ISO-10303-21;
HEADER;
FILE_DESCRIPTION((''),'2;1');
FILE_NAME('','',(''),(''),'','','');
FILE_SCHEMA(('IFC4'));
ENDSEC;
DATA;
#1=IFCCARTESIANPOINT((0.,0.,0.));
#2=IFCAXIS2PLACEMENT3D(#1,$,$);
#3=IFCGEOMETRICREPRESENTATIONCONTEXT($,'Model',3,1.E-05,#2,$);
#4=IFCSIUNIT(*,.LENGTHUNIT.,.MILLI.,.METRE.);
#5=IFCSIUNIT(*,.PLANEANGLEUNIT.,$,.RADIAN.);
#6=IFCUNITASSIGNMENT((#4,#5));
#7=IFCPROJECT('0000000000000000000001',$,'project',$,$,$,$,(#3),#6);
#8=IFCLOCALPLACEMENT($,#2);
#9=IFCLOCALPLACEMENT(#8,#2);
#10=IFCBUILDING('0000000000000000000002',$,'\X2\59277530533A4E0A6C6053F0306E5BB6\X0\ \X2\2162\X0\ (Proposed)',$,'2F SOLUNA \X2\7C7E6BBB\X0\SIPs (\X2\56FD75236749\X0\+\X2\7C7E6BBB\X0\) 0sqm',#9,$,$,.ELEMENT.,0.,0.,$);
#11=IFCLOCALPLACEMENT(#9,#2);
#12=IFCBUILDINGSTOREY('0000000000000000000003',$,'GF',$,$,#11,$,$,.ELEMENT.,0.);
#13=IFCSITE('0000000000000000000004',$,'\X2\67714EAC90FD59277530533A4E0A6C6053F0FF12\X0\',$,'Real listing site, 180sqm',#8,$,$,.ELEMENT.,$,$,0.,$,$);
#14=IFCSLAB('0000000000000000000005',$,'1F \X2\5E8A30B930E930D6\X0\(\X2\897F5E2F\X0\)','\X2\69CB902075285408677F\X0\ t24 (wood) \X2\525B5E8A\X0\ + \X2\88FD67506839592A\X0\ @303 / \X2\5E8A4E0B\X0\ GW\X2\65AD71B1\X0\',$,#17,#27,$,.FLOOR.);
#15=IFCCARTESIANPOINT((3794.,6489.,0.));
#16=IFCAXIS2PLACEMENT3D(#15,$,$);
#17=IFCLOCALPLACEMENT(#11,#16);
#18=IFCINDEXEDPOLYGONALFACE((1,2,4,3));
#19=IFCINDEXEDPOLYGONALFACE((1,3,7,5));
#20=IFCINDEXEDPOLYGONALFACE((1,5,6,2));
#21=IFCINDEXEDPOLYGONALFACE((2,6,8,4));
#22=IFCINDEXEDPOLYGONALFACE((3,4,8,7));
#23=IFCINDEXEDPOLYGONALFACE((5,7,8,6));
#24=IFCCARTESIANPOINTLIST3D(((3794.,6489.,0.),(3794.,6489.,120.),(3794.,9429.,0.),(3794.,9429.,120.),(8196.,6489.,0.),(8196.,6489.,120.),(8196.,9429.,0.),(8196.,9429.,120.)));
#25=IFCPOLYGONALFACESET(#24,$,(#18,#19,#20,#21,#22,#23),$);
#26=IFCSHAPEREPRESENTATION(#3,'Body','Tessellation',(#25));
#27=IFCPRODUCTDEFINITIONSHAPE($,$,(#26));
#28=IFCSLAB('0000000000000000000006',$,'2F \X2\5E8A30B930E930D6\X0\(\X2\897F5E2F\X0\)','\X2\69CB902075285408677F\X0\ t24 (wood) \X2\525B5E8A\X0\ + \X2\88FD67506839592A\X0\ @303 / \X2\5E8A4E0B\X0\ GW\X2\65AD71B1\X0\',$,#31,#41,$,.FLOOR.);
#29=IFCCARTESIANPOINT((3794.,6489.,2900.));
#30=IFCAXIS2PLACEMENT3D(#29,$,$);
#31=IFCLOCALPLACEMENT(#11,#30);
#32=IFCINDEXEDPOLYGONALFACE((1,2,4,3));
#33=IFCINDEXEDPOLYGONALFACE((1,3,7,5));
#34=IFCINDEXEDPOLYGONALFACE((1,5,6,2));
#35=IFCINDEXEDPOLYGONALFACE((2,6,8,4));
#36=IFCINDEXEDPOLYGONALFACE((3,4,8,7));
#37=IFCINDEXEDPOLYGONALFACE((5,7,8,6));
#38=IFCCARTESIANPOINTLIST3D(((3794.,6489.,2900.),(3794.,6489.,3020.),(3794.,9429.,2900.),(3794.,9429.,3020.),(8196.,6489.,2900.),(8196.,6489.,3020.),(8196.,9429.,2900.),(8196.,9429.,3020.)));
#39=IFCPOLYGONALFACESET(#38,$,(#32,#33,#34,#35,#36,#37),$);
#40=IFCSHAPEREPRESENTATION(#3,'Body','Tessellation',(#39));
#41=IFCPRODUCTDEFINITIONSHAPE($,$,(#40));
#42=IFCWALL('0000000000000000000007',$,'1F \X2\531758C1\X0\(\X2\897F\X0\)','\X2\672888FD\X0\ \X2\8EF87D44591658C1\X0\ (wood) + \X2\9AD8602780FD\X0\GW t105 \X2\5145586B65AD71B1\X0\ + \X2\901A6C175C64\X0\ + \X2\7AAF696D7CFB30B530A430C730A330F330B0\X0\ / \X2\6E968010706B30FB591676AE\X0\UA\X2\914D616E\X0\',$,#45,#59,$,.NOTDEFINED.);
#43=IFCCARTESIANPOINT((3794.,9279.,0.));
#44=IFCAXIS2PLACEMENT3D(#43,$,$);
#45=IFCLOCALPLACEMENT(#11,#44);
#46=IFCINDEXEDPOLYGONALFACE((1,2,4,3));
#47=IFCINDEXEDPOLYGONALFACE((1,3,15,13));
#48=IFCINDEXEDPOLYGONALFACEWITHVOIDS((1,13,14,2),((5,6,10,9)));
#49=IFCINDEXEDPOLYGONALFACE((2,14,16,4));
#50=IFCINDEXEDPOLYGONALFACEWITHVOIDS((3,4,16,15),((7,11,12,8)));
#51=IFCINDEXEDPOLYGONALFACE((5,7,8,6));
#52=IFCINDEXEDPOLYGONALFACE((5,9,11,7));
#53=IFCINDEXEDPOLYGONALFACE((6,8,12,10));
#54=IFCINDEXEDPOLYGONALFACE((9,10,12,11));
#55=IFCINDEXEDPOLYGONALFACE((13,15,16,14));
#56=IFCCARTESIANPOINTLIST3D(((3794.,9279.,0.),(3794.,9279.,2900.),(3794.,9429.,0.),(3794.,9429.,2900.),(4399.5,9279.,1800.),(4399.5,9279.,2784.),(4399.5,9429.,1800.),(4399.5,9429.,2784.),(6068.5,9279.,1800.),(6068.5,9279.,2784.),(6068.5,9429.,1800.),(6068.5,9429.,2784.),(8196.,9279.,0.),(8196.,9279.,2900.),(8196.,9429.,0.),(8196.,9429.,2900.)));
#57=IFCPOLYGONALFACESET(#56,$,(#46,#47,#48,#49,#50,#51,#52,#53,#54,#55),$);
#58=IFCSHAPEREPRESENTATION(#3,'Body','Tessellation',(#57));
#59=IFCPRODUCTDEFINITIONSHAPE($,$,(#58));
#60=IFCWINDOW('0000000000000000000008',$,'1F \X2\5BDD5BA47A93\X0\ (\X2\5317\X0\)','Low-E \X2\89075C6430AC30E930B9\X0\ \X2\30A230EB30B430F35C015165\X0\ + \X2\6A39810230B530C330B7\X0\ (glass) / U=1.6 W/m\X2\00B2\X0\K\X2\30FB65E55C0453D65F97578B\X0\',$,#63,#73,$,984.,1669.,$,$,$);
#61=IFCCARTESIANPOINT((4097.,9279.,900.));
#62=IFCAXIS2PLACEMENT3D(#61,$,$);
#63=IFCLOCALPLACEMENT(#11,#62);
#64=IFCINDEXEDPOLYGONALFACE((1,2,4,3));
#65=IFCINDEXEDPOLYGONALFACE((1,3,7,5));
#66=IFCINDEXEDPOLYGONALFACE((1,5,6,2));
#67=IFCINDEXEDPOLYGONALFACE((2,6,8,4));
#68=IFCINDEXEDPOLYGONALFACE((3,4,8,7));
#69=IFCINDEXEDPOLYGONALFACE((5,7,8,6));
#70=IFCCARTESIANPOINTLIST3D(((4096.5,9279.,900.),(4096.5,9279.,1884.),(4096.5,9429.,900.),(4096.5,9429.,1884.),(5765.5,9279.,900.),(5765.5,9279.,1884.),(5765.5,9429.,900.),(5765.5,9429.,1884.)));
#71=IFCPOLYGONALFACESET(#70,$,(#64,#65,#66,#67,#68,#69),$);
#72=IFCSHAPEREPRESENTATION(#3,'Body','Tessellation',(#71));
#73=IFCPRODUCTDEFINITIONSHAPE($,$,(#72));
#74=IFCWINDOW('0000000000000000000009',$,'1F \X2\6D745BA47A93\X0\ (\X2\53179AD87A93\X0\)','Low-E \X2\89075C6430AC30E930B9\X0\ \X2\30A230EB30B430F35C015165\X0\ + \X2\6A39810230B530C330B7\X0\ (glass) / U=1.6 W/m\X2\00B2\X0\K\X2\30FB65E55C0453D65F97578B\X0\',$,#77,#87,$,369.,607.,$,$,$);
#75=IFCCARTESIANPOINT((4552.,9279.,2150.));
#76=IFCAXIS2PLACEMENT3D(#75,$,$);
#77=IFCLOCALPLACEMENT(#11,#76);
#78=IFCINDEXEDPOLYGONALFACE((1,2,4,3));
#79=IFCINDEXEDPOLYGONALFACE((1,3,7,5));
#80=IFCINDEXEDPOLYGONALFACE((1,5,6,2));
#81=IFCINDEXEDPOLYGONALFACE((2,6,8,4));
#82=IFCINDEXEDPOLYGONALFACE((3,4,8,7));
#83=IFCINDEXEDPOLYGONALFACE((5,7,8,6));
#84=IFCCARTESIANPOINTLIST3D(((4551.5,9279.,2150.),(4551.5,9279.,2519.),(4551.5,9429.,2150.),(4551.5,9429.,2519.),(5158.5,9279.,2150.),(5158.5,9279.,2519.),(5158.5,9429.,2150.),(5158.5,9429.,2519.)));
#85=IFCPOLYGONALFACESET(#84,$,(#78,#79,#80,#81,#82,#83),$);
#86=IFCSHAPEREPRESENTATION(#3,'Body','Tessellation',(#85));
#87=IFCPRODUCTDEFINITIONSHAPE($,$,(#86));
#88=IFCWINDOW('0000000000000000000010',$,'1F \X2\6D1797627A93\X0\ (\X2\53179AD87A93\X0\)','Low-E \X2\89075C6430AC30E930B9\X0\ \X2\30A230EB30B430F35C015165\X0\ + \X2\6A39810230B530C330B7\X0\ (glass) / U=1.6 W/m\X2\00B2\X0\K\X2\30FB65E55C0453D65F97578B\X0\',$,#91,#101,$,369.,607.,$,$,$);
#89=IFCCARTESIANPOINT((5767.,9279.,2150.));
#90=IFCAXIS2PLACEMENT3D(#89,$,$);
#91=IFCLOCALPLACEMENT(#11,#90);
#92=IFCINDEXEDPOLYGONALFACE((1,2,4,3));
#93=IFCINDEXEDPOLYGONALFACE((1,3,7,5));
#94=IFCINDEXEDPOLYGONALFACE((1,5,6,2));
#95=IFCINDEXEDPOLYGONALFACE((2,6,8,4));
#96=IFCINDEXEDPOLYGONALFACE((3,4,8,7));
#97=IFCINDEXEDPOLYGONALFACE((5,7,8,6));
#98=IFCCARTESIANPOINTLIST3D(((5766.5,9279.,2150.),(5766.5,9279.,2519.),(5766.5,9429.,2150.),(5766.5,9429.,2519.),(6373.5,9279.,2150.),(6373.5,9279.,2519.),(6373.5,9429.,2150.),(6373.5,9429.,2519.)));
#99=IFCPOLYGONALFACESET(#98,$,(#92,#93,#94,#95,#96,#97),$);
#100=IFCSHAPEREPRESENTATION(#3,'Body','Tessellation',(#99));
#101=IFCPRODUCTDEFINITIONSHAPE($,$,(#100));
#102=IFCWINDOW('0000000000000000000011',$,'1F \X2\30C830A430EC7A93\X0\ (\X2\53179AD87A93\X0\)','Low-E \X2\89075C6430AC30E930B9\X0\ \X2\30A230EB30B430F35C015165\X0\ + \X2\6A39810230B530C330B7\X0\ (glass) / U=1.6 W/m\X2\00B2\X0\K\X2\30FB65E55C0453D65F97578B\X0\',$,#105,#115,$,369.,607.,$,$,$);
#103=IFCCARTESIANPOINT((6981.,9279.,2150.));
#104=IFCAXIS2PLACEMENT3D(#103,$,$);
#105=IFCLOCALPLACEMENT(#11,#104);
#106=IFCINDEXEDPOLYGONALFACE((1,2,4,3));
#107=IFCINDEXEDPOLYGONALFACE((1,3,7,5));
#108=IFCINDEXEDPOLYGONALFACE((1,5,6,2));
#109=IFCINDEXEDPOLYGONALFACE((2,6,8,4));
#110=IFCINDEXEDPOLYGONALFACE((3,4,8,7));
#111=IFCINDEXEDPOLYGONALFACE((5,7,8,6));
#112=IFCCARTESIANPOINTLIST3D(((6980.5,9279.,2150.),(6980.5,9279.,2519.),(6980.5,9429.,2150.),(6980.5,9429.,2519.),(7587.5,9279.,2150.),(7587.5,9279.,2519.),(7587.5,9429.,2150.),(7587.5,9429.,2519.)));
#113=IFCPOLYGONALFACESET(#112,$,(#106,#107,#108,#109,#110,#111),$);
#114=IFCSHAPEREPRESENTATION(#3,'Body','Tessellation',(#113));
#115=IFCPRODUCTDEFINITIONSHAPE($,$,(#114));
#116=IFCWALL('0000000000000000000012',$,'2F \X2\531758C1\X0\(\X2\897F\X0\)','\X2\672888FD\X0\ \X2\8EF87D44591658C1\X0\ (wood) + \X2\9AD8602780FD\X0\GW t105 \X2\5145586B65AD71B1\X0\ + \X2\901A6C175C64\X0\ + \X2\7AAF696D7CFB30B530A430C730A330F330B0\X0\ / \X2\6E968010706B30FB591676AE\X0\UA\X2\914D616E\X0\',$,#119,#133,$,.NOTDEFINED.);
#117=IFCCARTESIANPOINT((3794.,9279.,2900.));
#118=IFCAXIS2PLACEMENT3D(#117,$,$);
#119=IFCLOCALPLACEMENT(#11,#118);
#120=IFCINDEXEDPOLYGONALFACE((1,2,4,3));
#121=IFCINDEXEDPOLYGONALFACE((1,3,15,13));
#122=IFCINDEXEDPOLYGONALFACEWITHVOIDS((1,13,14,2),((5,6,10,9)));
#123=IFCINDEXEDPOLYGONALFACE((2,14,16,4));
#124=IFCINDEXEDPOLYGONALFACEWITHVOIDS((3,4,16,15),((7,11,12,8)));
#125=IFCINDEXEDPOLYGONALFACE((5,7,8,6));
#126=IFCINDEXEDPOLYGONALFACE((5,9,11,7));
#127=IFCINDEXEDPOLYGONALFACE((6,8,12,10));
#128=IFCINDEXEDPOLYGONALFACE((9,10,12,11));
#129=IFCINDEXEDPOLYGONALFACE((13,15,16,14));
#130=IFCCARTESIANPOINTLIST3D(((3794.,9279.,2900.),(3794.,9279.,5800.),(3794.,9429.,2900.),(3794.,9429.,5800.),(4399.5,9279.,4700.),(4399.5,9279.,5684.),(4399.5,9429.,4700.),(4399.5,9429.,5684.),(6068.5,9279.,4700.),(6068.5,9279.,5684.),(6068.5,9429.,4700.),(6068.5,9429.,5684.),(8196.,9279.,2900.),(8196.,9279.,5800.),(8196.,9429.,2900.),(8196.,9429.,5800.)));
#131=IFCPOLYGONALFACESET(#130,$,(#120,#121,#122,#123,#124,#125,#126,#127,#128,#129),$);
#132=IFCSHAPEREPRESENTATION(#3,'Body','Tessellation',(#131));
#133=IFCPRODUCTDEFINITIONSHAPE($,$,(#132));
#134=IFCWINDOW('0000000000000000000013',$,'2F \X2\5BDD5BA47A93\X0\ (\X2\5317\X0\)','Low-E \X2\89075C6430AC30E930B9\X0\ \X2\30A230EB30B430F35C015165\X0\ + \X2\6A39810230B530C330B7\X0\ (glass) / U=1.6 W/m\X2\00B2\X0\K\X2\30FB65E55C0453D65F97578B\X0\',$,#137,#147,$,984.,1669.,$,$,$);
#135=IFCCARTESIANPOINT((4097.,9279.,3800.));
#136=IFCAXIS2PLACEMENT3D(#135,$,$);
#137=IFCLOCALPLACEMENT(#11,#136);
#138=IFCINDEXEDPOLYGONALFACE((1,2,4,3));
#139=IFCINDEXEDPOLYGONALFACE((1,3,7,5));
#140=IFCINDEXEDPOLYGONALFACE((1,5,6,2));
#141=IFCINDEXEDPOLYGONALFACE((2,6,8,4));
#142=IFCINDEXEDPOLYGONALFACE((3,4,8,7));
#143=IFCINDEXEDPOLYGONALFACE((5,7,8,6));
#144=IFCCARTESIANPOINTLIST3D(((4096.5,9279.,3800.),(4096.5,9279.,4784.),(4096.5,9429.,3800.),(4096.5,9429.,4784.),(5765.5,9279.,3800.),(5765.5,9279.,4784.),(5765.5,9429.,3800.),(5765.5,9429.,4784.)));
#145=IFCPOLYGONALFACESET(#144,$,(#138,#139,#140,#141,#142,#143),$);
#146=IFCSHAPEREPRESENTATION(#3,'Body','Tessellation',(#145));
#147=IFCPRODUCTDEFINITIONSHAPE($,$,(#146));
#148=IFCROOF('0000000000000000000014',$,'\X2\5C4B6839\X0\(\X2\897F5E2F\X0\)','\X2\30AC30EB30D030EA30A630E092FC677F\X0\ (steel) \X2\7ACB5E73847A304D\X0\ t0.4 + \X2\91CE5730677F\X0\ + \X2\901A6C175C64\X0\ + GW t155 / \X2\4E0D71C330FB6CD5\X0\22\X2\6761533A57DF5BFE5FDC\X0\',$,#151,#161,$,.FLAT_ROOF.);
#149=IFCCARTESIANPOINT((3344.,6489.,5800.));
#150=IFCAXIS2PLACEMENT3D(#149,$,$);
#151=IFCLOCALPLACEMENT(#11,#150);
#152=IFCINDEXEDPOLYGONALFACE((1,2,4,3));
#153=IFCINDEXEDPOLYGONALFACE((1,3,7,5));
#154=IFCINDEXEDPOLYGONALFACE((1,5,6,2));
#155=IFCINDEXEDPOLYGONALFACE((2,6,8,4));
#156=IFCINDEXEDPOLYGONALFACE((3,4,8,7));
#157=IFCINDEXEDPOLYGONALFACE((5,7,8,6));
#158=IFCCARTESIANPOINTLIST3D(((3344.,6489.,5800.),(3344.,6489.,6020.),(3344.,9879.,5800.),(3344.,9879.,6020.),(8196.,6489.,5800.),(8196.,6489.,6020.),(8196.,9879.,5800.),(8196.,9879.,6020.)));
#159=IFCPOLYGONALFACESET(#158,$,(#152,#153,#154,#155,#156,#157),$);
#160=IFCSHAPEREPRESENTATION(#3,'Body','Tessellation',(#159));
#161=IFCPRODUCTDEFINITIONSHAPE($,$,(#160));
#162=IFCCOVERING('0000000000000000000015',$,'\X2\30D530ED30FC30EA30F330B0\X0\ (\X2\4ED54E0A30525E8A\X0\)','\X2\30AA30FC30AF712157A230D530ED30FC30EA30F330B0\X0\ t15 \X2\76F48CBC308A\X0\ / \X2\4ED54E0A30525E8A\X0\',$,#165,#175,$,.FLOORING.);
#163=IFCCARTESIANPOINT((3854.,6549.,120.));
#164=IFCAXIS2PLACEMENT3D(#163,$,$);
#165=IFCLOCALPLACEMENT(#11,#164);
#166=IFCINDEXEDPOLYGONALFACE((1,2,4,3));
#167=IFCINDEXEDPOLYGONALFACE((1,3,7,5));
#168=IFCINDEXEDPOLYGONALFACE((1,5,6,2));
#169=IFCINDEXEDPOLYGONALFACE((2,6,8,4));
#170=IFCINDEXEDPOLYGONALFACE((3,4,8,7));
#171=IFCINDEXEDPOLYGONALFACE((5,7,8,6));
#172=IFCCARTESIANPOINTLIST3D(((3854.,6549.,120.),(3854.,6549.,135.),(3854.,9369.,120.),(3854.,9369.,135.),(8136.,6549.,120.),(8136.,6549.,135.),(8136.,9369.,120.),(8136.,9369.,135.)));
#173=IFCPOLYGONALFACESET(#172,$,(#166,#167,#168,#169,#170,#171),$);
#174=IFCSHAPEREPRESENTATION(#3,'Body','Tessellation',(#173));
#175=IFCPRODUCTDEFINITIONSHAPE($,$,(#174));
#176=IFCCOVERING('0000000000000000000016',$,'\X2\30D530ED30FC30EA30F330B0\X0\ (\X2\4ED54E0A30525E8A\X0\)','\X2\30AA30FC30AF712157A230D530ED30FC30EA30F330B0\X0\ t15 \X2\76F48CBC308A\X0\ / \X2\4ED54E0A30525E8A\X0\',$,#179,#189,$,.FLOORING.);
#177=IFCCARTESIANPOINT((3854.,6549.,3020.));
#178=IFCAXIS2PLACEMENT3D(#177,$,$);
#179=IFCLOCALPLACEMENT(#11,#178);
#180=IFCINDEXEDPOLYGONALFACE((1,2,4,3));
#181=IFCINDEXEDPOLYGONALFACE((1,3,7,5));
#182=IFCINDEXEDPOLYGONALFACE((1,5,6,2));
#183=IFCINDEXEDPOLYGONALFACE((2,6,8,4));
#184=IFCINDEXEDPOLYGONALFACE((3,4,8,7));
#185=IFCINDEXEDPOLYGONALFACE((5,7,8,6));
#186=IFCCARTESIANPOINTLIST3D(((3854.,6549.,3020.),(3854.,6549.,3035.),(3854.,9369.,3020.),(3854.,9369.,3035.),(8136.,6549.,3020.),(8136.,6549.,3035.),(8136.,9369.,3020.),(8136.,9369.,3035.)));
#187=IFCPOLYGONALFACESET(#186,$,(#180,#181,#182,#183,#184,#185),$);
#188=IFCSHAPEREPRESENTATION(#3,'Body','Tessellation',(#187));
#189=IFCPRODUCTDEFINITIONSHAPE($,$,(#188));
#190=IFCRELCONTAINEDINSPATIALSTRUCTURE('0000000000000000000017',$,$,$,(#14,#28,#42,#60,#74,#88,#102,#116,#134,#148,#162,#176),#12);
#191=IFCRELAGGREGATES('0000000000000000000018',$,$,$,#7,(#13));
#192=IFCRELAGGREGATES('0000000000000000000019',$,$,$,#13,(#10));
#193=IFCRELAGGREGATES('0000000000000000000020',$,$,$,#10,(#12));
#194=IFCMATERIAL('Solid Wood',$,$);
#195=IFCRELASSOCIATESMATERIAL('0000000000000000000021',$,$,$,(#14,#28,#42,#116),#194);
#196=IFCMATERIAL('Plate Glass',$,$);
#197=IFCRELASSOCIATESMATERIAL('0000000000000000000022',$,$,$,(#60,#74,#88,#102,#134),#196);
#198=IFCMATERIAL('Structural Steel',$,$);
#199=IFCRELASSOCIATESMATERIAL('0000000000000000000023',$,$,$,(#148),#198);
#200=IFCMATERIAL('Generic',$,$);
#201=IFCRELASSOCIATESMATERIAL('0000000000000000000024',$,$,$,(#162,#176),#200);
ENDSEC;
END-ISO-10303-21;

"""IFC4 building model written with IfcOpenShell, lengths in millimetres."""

from ifc_helpers import new_model, si_unit, frame, frame_2d, origin, place, context, project, spatial, rectangle, extrude, material, element, fill, save


model = new_model("IFC4")

# Units and contexts
model_context = context("Model", 3, precision=1e-05, world=origin())
ifc_project = project(units=[si_unit("LENGTHUNIT", "METRE", prefix="MILLI"), si_unit("PLANEANGLEUNIT", "RADIAN")], contexts=[model_context])

# Site, building, storey
site_placement = place(None, origin())
site = spatial("IfcSite", under=ifc_project, at=site_placement, Name="東京都大田区上池台２", ObjectType="Real listing site, 180sqm", CompositionType="ELEMENT", RefElevation=0.0)
building_placement = place(site_placement, origin())
building = spatial("IfcBuilding", under=site, at=building_placement, Name="大田区上池台の家 Ⅲ (Proposed)", ObjectType="2F SOLUNA 籾殻SIPs (国産杉+籾殻) 0sqm", CompositionType="ELEMENT", ElevationOfRefHeight=0.0, ElevationOfTerrain=0.0)
storey_placement = place(building_placement, origin())
storey = spatial("IfcBuildingStorey", under=building, at=storey_placement, Name="GF", CompositionType="ELEMENT", Elevation=0.0)

# Slabs
ifc_material_1 = material(Name="Solid Wood")
slab_1_placement = place(storey_placement, frame((3794.0, 6489.0, 0.0)))
element("IfcSlab", 1, at=slab_1_placement, inside=storey, material=ifc_material_1, Name="1F 床スラブ(西帯)", Description="構造用合板 t24 (wood) 剛床 + 製材根太 @303 / 床下 GW断熱", PredefinedType="FLOOR", context=model_context, shape_type="SweptSolid", body=[
    extrude(rectangle(XDim=4402.0, YDim=2940.0, at=frame_2d((2201.0, 1470.0))), frame((3794.0, 6489.0, 0.0)), (0.0, 0.0, 1.0), 120.0),
])
slab_2_placement = place(storey_placement, frame((3794.0, 6489.0, 2900.0)))
element("IfcSlab", 2, at=slab_2_placement, inside=storey, material=ifc_material_1, Name="2F 床スラブ(西帯)", Description="構造用合板 t24 (wood) 剛床 + 製材根太 @303 / 床下 GW断熱", PredefinedType="FLOOR", context=model_context, shape_type="SweptSolid", body=[
    extrude(rectangle(XDim=4402.0, YDim=2940.0, at=frame_2d((2201.0, 1470.0))), frame((3794.0, 6489.0, 2900.0)), (0.0, 0.0, 1.0), 120.0),
])

# Wall, openings, windows
wall_1_placement = place(storey_placement, frame((3794.0, 9279.0, 0.0)))
wall_1 = element("IfcWall", 3, at=wall_1_placement, inside=storey, material=ifc_material_1, Name="1F 北壁(西)", Description="木製 軸組外壁 (wood) + 高性能GW t105 充填断熱 + 通気層 + 窯業系サイディング / 準耐火・外皮UA配慮", PredefinedType="NOTDEFINED", context=model_context, shape_type="SweptSolid", body=[
    extrude(rectangle(XDim=4402.0, YDim=150.0, at=frame_2d((2201.0, 75.0))), frame((3794.0, 9279.0, 0.0)), (0.0, 0.0, 1.0), 2900.0),
])
opening_1_placement = place(storey_placement, frame((4097.0, 9279.0, 900.0)))
opening_1 = element("IfcOpeningElement", 4, at=opening_1_placement, cuts=wall_1, PredefinedType="NOTDEFINED", context=model_context, shape_type="SweptSolid", body=[
    extrude(rectangle(XDim=1669.0, YDim=150.0, at=frame_2d((834.0, 75.0))), frame((4097.0, 9279.0, 900.0)), (0.0, 0.0, 1.0), 984.0),
])
opening_2_placement = place(storey_placement, frame((4552.0, 9279.0, 2150.0)))
opening_2 = element("IfcOpeningElement", 5, at=opening_2_placement, cuts=wall_1, PredefinedType="NOTDEFINED", context=model_context, shape_type="SweptSolid", body=[
    extrude(rectangle(XDim=607.0, YDim=150.0, at=frame_2d((303.0, 75.0))), frame((4552.0, 9279.0, 2150.0)), (0.0, 0.0, 1.0), 369.0),
])
opening_3_placement = place(storey_placement, frame((5767.0, 9279.0, 2150.0)))
opening_3 = element("IfcOpeningElement", 6, at=opening_3_placement, cuts=wall_1, PredefinedType="NOTDEFINED", context=model_context, shape_type="SweptSolid", body=[
    extrude(rectangle(XDim=607.0, YDim=150.0, at=frame_2d((303.0, 75.0))), frame((5767.0, 9279.0, 2150.0)), (0.0, 0.0, 1.0), 369.0),
])
opening_4_placement = place(storey_placement, frame((6981.0, 9279.0, 2150.0)))
opening_4 = element("IfcOpeningElement", 7, at=opening_4_placement, cuts=wall_1, PredefinedType="NOTDEFINED", context=model_context, shape_type="SweptSolid", body=[
    extrude(rectangle(XDim=607.0, YDim=150.0, at=frame_2d((303.0, 75.0))), frame((6981.0, 9279.0, 2150.0)), (0.0, 0.0, 1.0), 369.0),
])
ifc_material_2 = material(Name="Plate Glass")
window_1_placement = place(storey_placement, frame((4097.0, 9279.0, 900.0)))
window_1 = element("IfcWindow", 8, at=window_1_placement, inside=storey, material=ifc_material_2, Name="1F 寝室窓 (北)", Description="Low-E 複層ガラス アルゴン封入 + 樹脂サッシ (glass) / U=1.6 W/m²K・日射取得型", OverallHeight=984.0, OverallWidth=1669.0, context=model_context, shape_type="SweptSolid", body=[
    extrude(rectangle(XDim=1669.0, YDim=150.0, at=frame_2d((834.0, 75.0))), frame((4097.0, 9279.0, 900.0)), (0.0, 0.0, 1.0), 984.0),
])
fill(opening_1, window_1)
window_2_placement = place(storey_placement, frame((4552.0, 9279.0, 2150.0)))
window_2 = element("IfcWindow", 9, at=window_2_placement, inside=storey, material=ifc_material_2, Name="1F 浴室窓 (北高窓)", Description="Low-E 複層ガラス アルゴン封入 + 樹脂サッシ (glass) / U=1.6 W/m²K・日射取得型", OverallHeight=369.0, OverallWidth=607.0, context=model_context, shape_type="SweptSolid", body=[
    extrude(rectangle(XDim=607.0, YDim=150.0, at=frame_2d((303.0, 75.0))), frame((4552.0, 9279.0, 2150.0)), (0.0, 0.0, 1.0), 369.0),
])
fill(opening_2, window_2)
window_3_placement = place(storey_placement, frame((5767.0, 9279.0, 2150.0)))
window_3 = element("IfcWindow", 10, at=window_3_placement, inside=storey, material=ifc_material_2, Name="1F 洗面窓 (北高窓)", Description="Low-E 複層ガラス アルゴン封入 + 樹脂サッシ (glass) / U=1.6 W/m²K・日射取得型", OverallHeight=369.0, OverallWidth=607.0, context=model_context, shape_type="SweptSolid", body=[
    extrude(rectangle(XDim=607.0, YDim=150.0, at=frame_2d((303.0, 75.0))), frame((5767.0, 9279.0, 2150.0)), (0.0, 0.0, 1.0), 369.0),
])
fill(opening_3, window_3)
window_4_placement = place(storey_placement, frame((6981.0, 9279.0, 2150.0)))
window_4 = element("IfcWindow", 11, at=window_4_placement, inside=storey, material=ifc_material_2, Name="1F トイレ窓 (北高窓)", Description="Low-E 複層ガラス アルゴン封入 + 樹脂サッシ (glass) / U=1.6 W/m²K・日射取得型", OverallHeight=369.0, OverallWidth=607.0, context=model_context, shape_type="SweptSolid", body=[
    extrude(rectangle(XDim=607.0, YDim=150.0, at=frame_2d((303.0, 75.0))), frame((6981.0, 9279.0, 2150.0)), (0.0, 0.0, 1.0), 369.0),
])
fill(opening_4, window_4)

# Wall, opening, window
wall_2_placement = place(storey_placement, frame((3794.0, 9279.0, 2900.0)))
wall_2 = element("IfcWall", 12, at=wall_2_placement, inside=storey, material=ifc_material_1, Name="2F 北壁(西)", Description="木製 軸組外壁 (wood) + 高性能GW t105 充填断熱 + 通気層 + 窯業系サイディング / 準耐火・外皮UA配慮", PredefinedType="NOTDEFINED", context=model_context, shape_type="SweptSolid", body=[
    extrude(rectangle(XDim=4402.0, YDim=150.0, at=frame_2d((2201.0, 75.0))), frame((3794.0, 9279.0, 2900.0)), (0.0, 0.0, 1.0), 2900.0),
])
opening_5_placement = place(storey_placement, frame((4097.0, 9279.0, 3800.0)))
opening_5 = element("IfcOpeningElement", 13, at=opening_5_placement, cuts=wall_2, PredefinedType="NOTDEFINED", context=model_context, shape_type="SweptSolid", body=[
    extrude(rectangle(XDim=1669.0, YDim=150.0, at=frame_2d((834.0, 75.0))), frame((4097.0, 9279.0, 3800.0)), (0.0, 0.0, 1.0), 984.0),
])
window_5_placement = place(storey_placement, frame((4097.0, 9279.0, 3800.0)))
window_5 = element("IfcWindow", 14, at=window_5_placement, inside=storey, material=ifc_material_2, Name="2F 寝室窓 (北)", Description="Low-E 複層ガラス アルゴン封入 + 樹脂サッシ (glass) / U=1.6 W/m²K・日射取得型", OverallHeight=984.0, OverallWidth=1669.0, context=model_context, shape_type="SweptSolid", body=[
    extrude(rectangle(XDim=1669.0, YDim=150.0, at=frame_2d((834.0, 75.0))), frame((4097.0, 9279.0, 3800.0)), (0.0, 0.0, 1.0), 984.0),
])
fill(opening_5, window_5)

# Roof
ifc_material_3 = material(Name="Structural Steel")
for number, where, name in (
    (15, (3344.0, 6489.0, 5800.0), "屋根(西帯)"),
):
    element("IfcRoof", number, at=place(storey_placement, frame(where)), inside=storey, material=ifc_material_3, Name=name, Description="ガルバリウム鋼板 (steel) 立平葺き t0.4 + 野地板 + 通気層 + GW t155 / 不燃・法22条区域対応", PredefinedType="FLAT_ROOF", context=model_context, shape_type="SweptSolid", body=[
        extrude(rectangle(XDim=4852.0, YDim=3390.0, at=frame_2d((2426.0, 1695.0))), frame((3344.0, 6489.0, 5800.0)), (0.0, 0.0, 1.0), 220.0),
    ])

# Coverings
ifc_material_4 = material(Name="Generic")
covering_1_placement = place(storey_placement, frame((3854.0, 6549.0, 120.0)))
element("IfcCovering", 16, at=covering_1_placement, inside=storey, material=ifc_material_4, Name="フローリング (仕上げ床)", Description="オーク無垢フローリング t15 直貼り / 仕上げ床", PredefinedType="FLOORING", context=model_context, shape_type="SweptSolid", body=[
    extrude(rectangle(XDim=4282.0, YDim=2820.0, at=frame_2d((2141.0, 1410.0))), frame((3854.0, 6549.0, 120.0)), (0.0, 0.0, 1.0), 15.0),
])
covering_2_placement = place(storey_placement, frame((3854.0, 6549.0, 3020.0)))
element("IfcCovering", 17, at=covering_2_placement, inside=storey, material=ifc_material_4, Name="フローリング (仕上げ床)", Description="オーク無垢フローリング t15 直貼り / 仕上げ床", PredefinedType="FLOORING", context=model_context, shape_type="SweptSolid", body=[
    extrude(rectangle(XDim=4282.0, YDim=2820.0, at=frame_2d((2141.0, 1410.0))), frame((3854.0, 6549.0, 3020.0)), (0.0, 0.0, 1.0), 15.0),
])

save(model, "model.ifc")
